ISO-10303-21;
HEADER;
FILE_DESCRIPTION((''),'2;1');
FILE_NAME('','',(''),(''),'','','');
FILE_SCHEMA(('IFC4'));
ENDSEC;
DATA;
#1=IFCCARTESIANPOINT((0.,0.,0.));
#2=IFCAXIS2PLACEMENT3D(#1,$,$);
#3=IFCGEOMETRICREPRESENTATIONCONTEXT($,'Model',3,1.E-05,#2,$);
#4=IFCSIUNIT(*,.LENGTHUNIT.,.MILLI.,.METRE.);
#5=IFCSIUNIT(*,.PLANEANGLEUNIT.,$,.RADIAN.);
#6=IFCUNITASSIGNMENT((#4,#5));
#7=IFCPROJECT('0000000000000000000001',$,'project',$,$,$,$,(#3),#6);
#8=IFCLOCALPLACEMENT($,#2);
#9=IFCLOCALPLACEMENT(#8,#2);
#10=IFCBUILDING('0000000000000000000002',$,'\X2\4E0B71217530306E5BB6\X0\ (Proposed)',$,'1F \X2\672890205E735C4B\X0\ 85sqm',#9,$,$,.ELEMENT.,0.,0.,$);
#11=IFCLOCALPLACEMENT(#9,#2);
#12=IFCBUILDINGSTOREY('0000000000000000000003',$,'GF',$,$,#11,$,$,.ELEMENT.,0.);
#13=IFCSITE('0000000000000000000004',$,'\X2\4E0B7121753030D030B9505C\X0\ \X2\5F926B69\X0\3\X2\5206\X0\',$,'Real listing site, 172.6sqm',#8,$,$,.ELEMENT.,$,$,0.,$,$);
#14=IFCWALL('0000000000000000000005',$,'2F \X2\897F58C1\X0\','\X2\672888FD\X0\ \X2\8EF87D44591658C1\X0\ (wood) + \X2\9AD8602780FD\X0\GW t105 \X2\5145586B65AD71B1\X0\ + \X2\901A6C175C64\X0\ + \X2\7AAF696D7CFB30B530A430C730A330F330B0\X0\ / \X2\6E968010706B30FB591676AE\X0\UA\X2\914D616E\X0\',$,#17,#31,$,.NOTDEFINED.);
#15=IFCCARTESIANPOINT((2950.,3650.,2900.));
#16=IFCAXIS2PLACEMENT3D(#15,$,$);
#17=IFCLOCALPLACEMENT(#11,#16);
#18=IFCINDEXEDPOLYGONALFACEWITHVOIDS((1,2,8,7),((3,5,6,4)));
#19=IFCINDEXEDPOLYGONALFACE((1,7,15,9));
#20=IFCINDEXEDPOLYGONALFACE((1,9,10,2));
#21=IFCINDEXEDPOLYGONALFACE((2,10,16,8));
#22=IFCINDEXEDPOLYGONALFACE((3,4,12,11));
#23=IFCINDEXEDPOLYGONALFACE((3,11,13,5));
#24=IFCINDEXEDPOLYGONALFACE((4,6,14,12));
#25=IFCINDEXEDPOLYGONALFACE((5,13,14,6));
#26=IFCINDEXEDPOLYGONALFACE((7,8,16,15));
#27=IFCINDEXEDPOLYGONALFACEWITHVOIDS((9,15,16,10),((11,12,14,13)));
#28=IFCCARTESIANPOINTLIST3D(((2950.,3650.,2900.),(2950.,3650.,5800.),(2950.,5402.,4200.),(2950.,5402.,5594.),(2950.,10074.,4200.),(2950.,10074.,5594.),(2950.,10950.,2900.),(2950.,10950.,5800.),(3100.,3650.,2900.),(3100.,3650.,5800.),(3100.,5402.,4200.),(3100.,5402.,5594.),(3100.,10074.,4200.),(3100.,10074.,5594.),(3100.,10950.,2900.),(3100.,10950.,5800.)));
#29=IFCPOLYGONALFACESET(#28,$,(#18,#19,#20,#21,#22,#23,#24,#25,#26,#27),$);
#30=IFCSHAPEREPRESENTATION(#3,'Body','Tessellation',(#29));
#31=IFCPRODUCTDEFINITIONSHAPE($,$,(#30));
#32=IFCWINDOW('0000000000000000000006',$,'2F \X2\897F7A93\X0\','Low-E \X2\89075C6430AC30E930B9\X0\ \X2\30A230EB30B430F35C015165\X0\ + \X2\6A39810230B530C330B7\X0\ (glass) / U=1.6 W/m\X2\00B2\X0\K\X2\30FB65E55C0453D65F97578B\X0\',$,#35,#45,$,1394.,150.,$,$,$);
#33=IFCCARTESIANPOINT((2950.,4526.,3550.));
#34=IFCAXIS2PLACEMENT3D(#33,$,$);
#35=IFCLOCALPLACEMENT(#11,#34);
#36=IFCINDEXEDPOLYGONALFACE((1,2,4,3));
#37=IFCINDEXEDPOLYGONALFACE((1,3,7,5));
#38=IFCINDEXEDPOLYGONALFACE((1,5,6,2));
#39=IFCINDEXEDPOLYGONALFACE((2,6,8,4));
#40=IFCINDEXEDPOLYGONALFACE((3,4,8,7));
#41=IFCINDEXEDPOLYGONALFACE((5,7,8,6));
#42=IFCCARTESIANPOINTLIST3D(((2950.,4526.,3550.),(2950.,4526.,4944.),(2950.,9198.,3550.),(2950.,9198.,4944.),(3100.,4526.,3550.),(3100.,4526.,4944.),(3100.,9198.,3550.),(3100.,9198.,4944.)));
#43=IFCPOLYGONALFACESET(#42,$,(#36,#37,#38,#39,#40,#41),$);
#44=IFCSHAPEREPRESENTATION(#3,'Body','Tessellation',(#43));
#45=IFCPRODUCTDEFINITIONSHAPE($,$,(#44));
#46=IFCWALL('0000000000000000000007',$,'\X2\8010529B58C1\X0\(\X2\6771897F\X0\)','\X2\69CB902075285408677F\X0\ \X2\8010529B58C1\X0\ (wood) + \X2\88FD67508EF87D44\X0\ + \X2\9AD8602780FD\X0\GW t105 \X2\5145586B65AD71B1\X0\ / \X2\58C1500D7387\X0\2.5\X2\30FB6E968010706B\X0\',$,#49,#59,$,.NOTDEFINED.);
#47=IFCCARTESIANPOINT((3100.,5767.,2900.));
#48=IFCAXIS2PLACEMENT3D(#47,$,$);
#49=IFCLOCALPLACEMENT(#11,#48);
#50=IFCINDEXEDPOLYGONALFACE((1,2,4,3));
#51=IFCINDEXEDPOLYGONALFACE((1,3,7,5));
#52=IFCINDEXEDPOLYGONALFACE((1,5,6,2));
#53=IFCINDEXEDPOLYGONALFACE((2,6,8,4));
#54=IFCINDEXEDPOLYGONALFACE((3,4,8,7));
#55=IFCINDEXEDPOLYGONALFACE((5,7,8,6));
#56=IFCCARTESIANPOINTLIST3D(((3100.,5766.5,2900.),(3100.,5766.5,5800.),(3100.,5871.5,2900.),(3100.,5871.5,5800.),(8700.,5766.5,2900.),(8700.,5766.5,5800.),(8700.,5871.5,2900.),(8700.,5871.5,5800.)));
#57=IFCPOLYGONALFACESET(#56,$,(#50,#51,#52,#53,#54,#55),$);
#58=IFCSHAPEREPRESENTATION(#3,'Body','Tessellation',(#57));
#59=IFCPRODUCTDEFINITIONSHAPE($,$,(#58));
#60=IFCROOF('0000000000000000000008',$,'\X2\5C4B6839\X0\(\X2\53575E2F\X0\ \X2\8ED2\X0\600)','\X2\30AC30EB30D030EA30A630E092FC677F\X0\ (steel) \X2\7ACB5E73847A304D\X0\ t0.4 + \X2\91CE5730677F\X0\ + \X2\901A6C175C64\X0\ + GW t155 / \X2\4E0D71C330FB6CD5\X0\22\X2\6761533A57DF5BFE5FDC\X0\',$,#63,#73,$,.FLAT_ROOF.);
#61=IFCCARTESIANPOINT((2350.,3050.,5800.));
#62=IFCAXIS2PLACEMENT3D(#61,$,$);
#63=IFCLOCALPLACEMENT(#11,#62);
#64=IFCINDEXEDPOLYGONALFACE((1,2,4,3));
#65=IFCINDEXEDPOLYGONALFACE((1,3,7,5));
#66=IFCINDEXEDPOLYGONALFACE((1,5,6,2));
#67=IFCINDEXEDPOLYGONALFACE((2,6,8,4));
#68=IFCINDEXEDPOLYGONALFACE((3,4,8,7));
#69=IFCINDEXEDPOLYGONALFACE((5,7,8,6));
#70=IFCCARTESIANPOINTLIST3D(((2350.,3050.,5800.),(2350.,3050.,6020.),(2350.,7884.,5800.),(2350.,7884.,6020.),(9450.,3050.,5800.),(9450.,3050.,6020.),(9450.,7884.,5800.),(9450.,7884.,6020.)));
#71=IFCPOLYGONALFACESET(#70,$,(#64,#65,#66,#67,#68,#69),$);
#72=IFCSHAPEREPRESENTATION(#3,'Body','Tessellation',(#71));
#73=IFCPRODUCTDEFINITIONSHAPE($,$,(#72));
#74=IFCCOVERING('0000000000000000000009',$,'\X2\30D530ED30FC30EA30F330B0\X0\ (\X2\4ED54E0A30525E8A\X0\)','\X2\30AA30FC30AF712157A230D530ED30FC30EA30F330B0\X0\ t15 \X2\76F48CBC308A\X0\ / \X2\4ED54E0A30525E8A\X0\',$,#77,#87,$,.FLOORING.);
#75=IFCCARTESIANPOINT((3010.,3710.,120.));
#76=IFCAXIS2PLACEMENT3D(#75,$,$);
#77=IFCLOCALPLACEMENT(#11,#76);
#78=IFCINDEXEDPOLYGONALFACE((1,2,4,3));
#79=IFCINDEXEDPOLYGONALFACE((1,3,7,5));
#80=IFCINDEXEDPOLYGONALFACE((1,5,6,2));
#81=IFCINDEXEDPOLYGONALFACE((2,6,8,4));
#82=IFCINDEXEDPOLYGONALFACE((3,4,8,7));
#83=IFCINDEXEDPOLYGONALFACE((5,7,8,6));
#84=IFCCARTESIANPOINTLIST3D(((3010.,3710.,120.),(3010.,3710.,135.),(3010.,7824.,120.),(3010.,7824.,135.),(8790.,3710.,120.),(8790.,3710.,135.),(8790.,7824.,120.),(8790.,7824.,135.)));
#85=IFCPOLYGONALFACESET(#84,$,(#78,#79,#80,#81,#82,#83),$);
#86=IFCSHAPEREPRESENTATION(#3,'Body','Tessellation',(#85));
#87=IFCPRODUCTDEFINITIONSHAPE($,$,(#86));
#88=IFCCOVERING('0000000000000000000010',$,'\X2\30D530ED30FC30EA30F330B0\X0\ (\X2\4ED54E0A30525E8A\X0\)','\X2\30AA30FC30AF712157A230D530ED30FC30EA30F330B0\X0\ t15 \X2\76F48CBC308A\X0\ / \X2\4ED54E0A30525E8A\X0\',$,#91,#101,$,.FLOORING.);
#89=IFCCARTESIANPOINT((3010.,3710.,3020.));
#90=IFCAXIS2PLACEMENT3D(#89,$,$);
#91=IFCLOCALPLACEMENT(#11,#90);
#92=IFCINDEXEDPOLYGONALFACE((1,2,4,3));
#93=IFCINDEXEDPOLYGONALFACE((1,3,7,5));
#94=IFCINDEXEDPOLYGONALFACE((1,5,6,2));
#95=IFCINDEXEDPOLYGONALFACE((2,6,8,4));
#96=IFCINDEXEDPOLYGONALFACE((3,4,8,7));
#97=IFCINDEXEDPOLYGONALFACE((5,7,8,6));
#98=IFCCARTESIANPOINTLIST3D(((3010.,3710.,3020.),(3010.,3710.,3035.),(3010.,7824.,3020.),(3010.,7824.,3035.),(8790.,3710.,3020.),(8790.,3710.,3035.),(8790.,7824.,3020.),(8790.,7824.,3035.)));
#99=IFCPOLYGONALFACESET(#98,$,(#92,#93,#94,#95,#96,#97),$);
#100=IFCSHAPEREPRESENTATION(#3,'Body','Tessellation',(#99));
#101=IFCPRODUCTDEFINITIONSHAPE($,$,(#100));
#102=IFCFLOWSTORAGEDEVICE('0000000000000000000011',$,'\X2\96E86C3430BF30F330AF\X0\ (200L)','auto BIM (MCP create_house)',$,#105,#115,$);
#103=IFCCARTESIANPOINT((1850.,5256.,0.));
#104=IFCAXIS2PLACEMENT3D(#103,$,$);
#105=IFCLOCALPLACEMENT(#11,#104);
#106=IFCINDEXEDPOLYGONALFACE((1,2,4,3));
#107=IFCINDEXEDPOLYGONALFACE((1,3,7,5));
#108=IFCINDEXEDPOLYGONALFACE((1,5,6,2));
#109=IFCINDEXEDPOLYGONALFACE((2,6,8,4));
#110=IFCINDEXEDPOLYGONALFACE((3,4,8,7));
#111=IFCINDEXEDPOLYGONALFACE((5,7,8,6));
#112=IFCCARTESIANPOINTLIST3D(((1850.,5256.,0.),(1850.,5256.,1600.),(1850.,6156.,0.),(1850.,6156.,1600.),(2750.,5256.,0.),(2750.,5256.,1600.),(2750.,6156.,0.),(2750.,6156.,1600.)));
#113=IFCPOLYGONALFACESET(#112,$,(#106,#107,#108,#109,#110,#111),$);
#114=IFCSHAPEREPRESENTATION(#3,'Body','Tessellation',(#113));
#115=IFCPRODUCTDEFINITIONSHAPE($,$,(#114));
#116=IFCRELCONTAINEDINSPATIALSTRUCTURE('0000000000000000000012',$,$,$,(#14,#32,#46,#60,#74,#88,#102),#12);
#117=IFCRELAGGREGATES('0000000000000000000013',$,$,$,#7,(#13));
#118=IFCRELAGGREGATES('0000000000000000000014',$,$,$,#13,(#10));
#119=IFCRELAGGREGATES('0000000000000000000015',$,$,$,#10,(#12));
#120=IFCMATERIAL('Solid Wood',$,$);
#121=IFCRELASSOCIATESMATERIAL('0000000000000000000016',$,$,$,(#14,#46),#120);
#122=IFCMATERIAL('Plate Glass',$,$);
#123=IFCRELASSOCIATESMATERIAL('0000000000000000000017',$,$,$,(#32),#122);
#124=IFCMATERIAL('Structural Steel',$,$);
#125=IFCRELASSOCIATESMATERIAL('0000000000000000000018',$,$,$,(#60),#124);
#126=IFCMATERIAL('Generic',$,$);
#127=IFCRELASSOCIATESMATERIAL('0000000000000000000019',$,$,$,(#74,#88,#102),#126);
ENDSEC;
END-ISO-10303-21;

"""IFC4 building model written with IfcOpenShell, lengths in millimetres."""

from ifc_helpers import new_model, si_unit, frame, frame_2d, origin, place, context, project, spatial, rectangle, extrude, material, element, fill, save


model = new_model("IFC4")

# Units and contexts
model_context = context("Model", 3, precision=1e-05, world=origin())
ifc_project = project(units=[si_unit("LENGTHUNIT", "METRE", prefix="MILLI"), si_unit("PLANEANGLEUNIT", "RADIAN")], contexts=[model_context])

# Site, building, storey
site_placement = place(None, origin())
site = spatial("IfcSite", under=ifc_project, at=site_placement, Name="下無田バス停 徒歩3分", ObjectType="Real listing site, 172.6sqm", CompositionType="ELEMENT", RefElevation=0.0)
building_placement = place(site_placement, origin())
building = spatial("IfcBuilding", under=site, at=building_placement, Name="下無田の家 (Proposed)", ObjectType="1F 木造平屋 85sqm", CompositionType="ELEMENT", ElevationOfRefHeight=0.0, ElevationOfTerrain=0.0)
storey_placement = place(building_placement, origin())
storey = spatial("IfcBuildingStorey", under=building, at=storey_placement, Name="GF", CompositionType="ELEMENT", Elevation=0.0)

# Shared definitions
ifc_material_1 = material(Name="Solid Wood")
ifc_material_2 = material(Name="Generic")

# Shared definitions
ifc_material_3 = material(Name="Plate Glass")

# Wall, opening, window
wall_1_placement = place(storey_placement, frame((2950.0, 3650.0, 2900.0)))
wall_1 = element("IfcWall", 1, at=wall_1_placement, inside=storey, material=ifc_material_1, Name="2F 西壁", Description="木製 軸組外壁 (wood) + 高性能GW t105 充填断熱 + 通気層 + 窯業系サイディング / 準耐火・外皮UA配慮", PredefinedType="NOTDEFINED", context=model_context, shape_type="SweptSolid", body=[
    extrude(rectangle(XDim=150.0, YDim=7300.0, at=frame_2d((75.0, 3650.0))), frame((2950.0, 3650.0, 2900.0)), (0.0, 0.0, 1.0), 2900.0),
])
opening_1_placement = place(storey_placement, frame((2950.0, 4526.0, 3550.0)))
opening_1 = element("IfcOpeningElement", 2, at=opening_1_placement, cuts=wall_1, PredefinedType="NOTDEFINED", context=model_context, shape_type="SweptSolid", body=[
    extrude(rectangle(XDim=150.0, YDim=4672.0, at=frame_2d((75.0, 2336.0))), frame((2950.0, 4526.0, 3550.0)), (0.0, 0.0, 1.0), 1394.0),
])
window_1_placement = place(storey_placement, frame((2950.0, 4526.0, 3550.0)))
window_1 = element("IfcWindow", 3, at=window_1_placement, inside=storey, material=ifc_material_3, Name="2F 西窓", Description="Low-E 複層ガラス アルゴン封入 + 樹脂サッシ (glass) / U=1.6 W/m²K・日射取得型", OverallHeight=1394.0, OverallWidth=150.0, context=model_context, shape_type="SweptSolid", body=[
    extrude(rectangle(XDim=150.0, YDim=4672.0, at=frame_2d((75.0, 2336.0))), frame((2950.0, 4526.0, 3550.0)), (0.0, 0.0, 1.0), 1394.0),
])
fill(opening_1, window_1)

# Wall
wall_2_placement = place(storey_placement, frame((3100.0, 5767.0, 2900.0)))
element("IfcWall", 4, at=wall_2_placement, inside=storey, material=ifc_material_1, Name="耐力壁(東西)", Description="構造用合板 耐力壁 (wood) + 製材軸組 + 高性能GW t105 充填断熱 / 壁倍率2.5・準耐火", PredefinedType="NOTDEFINED", context=model_context, shape_type="SweptSolid", body=[
    extrude(rectangle(XDim=5600.0, YDim=105.0, at=frame_2d((2800.0, 52.0))), frame((3100.0, 5767.0, 2900.0)), (0.0, 0.0, 1.0), 2900.0),
])

# Roof
ifc_material_4 = material(Name="Structural Steel")
for number, where, name in (
    (5, (2350.0, 3050.0, 5800.0), "屋根(南帯 軒600)"),
):
    element("IfcRoof", number, at=place(storey_placement, frame(where)), inside=storey, material=ifc_material_4, Name=name, Description="ガルバリウム鋼板 (steel) 立平葺き t0.4 + 野地板 + 通気層 + GW t155 / 不燃・法22条区域対応", PredefinedType="FLAT_ROOF", context=model_context, shape_type="SweptSolid", body=[
        extrude(rectangle(XDim=7100.0, YDim=4834.0, at=frame_2d((3550.0, 2417.0))), frame((2350.0, 3050.0, 5800.0)), (0.0, 0.0, 1.0), 220.0),
    ])

# Coverings
covering_1_placement = place(storey_placement, frame((3010.0, 3710.0, 120.0)))
element("IfcCovering", 6, at=covering_1_placement, inside=storey, material=ifc_material_2, Name="フローリング (仕上げ床)", Description="オーク無垢フローリング t15 直貼り / 仕上げ床", PredefinedType="FLOORING", context=model_context, shape_type="SweptSolid", body=[
    extrude(rectangle(XDim=5780.0, YDim=4114.0, at=frame_2d((2890.0, 2057.0))), frame((3010.0, 3710.0, 120.0)), (0.0, 0.0, 1.0), 15.0),
])
covering_2_placement = place(storey_placement, frame((3010.0, 3710.0, 3020.0)))
element("IfcCovering", 7, at=covering_2_placement, inside=storey, material=ifc_material_2, Name="フローリング (仕上げ床)", Description="オーク無垢フローリング t15 直貼り / 仕上げ床", PredefinedType="FLOORING", context=model_context, shape_type="SweptSolid", body=[
    extrude(rectangle(XDim=5780.0, YDim=4114.0, at=frame_2d((2890.0, 2057.0))), frame((3010.0, 3710.0, 3020.0)), (0.0, 0.0, 1.0), 15.0),
])

# Flow storage device
flow_storage_device_placement = place(storey_placement, frame((1850.0, 5256.0, 0.0)))
element("IfcFlowStorageDevice", 8, at=flow_storage_device_placement, inside=storey, material=ifc_material_2, Name="雨水タンク (200L)", Description="auto BIM (MCP create_house)", context=model_context, shape_type="SweptSolid", body=[
    extrude(rectangle(XDim=900.0, YDim=900.0, at=frame_2d((450.0, 450.0))), frame((1850.0, 5256.0, 0.0)), (0.0, 0.0, 1.0), 1600.0),
])

save(model, "model.ifc")
